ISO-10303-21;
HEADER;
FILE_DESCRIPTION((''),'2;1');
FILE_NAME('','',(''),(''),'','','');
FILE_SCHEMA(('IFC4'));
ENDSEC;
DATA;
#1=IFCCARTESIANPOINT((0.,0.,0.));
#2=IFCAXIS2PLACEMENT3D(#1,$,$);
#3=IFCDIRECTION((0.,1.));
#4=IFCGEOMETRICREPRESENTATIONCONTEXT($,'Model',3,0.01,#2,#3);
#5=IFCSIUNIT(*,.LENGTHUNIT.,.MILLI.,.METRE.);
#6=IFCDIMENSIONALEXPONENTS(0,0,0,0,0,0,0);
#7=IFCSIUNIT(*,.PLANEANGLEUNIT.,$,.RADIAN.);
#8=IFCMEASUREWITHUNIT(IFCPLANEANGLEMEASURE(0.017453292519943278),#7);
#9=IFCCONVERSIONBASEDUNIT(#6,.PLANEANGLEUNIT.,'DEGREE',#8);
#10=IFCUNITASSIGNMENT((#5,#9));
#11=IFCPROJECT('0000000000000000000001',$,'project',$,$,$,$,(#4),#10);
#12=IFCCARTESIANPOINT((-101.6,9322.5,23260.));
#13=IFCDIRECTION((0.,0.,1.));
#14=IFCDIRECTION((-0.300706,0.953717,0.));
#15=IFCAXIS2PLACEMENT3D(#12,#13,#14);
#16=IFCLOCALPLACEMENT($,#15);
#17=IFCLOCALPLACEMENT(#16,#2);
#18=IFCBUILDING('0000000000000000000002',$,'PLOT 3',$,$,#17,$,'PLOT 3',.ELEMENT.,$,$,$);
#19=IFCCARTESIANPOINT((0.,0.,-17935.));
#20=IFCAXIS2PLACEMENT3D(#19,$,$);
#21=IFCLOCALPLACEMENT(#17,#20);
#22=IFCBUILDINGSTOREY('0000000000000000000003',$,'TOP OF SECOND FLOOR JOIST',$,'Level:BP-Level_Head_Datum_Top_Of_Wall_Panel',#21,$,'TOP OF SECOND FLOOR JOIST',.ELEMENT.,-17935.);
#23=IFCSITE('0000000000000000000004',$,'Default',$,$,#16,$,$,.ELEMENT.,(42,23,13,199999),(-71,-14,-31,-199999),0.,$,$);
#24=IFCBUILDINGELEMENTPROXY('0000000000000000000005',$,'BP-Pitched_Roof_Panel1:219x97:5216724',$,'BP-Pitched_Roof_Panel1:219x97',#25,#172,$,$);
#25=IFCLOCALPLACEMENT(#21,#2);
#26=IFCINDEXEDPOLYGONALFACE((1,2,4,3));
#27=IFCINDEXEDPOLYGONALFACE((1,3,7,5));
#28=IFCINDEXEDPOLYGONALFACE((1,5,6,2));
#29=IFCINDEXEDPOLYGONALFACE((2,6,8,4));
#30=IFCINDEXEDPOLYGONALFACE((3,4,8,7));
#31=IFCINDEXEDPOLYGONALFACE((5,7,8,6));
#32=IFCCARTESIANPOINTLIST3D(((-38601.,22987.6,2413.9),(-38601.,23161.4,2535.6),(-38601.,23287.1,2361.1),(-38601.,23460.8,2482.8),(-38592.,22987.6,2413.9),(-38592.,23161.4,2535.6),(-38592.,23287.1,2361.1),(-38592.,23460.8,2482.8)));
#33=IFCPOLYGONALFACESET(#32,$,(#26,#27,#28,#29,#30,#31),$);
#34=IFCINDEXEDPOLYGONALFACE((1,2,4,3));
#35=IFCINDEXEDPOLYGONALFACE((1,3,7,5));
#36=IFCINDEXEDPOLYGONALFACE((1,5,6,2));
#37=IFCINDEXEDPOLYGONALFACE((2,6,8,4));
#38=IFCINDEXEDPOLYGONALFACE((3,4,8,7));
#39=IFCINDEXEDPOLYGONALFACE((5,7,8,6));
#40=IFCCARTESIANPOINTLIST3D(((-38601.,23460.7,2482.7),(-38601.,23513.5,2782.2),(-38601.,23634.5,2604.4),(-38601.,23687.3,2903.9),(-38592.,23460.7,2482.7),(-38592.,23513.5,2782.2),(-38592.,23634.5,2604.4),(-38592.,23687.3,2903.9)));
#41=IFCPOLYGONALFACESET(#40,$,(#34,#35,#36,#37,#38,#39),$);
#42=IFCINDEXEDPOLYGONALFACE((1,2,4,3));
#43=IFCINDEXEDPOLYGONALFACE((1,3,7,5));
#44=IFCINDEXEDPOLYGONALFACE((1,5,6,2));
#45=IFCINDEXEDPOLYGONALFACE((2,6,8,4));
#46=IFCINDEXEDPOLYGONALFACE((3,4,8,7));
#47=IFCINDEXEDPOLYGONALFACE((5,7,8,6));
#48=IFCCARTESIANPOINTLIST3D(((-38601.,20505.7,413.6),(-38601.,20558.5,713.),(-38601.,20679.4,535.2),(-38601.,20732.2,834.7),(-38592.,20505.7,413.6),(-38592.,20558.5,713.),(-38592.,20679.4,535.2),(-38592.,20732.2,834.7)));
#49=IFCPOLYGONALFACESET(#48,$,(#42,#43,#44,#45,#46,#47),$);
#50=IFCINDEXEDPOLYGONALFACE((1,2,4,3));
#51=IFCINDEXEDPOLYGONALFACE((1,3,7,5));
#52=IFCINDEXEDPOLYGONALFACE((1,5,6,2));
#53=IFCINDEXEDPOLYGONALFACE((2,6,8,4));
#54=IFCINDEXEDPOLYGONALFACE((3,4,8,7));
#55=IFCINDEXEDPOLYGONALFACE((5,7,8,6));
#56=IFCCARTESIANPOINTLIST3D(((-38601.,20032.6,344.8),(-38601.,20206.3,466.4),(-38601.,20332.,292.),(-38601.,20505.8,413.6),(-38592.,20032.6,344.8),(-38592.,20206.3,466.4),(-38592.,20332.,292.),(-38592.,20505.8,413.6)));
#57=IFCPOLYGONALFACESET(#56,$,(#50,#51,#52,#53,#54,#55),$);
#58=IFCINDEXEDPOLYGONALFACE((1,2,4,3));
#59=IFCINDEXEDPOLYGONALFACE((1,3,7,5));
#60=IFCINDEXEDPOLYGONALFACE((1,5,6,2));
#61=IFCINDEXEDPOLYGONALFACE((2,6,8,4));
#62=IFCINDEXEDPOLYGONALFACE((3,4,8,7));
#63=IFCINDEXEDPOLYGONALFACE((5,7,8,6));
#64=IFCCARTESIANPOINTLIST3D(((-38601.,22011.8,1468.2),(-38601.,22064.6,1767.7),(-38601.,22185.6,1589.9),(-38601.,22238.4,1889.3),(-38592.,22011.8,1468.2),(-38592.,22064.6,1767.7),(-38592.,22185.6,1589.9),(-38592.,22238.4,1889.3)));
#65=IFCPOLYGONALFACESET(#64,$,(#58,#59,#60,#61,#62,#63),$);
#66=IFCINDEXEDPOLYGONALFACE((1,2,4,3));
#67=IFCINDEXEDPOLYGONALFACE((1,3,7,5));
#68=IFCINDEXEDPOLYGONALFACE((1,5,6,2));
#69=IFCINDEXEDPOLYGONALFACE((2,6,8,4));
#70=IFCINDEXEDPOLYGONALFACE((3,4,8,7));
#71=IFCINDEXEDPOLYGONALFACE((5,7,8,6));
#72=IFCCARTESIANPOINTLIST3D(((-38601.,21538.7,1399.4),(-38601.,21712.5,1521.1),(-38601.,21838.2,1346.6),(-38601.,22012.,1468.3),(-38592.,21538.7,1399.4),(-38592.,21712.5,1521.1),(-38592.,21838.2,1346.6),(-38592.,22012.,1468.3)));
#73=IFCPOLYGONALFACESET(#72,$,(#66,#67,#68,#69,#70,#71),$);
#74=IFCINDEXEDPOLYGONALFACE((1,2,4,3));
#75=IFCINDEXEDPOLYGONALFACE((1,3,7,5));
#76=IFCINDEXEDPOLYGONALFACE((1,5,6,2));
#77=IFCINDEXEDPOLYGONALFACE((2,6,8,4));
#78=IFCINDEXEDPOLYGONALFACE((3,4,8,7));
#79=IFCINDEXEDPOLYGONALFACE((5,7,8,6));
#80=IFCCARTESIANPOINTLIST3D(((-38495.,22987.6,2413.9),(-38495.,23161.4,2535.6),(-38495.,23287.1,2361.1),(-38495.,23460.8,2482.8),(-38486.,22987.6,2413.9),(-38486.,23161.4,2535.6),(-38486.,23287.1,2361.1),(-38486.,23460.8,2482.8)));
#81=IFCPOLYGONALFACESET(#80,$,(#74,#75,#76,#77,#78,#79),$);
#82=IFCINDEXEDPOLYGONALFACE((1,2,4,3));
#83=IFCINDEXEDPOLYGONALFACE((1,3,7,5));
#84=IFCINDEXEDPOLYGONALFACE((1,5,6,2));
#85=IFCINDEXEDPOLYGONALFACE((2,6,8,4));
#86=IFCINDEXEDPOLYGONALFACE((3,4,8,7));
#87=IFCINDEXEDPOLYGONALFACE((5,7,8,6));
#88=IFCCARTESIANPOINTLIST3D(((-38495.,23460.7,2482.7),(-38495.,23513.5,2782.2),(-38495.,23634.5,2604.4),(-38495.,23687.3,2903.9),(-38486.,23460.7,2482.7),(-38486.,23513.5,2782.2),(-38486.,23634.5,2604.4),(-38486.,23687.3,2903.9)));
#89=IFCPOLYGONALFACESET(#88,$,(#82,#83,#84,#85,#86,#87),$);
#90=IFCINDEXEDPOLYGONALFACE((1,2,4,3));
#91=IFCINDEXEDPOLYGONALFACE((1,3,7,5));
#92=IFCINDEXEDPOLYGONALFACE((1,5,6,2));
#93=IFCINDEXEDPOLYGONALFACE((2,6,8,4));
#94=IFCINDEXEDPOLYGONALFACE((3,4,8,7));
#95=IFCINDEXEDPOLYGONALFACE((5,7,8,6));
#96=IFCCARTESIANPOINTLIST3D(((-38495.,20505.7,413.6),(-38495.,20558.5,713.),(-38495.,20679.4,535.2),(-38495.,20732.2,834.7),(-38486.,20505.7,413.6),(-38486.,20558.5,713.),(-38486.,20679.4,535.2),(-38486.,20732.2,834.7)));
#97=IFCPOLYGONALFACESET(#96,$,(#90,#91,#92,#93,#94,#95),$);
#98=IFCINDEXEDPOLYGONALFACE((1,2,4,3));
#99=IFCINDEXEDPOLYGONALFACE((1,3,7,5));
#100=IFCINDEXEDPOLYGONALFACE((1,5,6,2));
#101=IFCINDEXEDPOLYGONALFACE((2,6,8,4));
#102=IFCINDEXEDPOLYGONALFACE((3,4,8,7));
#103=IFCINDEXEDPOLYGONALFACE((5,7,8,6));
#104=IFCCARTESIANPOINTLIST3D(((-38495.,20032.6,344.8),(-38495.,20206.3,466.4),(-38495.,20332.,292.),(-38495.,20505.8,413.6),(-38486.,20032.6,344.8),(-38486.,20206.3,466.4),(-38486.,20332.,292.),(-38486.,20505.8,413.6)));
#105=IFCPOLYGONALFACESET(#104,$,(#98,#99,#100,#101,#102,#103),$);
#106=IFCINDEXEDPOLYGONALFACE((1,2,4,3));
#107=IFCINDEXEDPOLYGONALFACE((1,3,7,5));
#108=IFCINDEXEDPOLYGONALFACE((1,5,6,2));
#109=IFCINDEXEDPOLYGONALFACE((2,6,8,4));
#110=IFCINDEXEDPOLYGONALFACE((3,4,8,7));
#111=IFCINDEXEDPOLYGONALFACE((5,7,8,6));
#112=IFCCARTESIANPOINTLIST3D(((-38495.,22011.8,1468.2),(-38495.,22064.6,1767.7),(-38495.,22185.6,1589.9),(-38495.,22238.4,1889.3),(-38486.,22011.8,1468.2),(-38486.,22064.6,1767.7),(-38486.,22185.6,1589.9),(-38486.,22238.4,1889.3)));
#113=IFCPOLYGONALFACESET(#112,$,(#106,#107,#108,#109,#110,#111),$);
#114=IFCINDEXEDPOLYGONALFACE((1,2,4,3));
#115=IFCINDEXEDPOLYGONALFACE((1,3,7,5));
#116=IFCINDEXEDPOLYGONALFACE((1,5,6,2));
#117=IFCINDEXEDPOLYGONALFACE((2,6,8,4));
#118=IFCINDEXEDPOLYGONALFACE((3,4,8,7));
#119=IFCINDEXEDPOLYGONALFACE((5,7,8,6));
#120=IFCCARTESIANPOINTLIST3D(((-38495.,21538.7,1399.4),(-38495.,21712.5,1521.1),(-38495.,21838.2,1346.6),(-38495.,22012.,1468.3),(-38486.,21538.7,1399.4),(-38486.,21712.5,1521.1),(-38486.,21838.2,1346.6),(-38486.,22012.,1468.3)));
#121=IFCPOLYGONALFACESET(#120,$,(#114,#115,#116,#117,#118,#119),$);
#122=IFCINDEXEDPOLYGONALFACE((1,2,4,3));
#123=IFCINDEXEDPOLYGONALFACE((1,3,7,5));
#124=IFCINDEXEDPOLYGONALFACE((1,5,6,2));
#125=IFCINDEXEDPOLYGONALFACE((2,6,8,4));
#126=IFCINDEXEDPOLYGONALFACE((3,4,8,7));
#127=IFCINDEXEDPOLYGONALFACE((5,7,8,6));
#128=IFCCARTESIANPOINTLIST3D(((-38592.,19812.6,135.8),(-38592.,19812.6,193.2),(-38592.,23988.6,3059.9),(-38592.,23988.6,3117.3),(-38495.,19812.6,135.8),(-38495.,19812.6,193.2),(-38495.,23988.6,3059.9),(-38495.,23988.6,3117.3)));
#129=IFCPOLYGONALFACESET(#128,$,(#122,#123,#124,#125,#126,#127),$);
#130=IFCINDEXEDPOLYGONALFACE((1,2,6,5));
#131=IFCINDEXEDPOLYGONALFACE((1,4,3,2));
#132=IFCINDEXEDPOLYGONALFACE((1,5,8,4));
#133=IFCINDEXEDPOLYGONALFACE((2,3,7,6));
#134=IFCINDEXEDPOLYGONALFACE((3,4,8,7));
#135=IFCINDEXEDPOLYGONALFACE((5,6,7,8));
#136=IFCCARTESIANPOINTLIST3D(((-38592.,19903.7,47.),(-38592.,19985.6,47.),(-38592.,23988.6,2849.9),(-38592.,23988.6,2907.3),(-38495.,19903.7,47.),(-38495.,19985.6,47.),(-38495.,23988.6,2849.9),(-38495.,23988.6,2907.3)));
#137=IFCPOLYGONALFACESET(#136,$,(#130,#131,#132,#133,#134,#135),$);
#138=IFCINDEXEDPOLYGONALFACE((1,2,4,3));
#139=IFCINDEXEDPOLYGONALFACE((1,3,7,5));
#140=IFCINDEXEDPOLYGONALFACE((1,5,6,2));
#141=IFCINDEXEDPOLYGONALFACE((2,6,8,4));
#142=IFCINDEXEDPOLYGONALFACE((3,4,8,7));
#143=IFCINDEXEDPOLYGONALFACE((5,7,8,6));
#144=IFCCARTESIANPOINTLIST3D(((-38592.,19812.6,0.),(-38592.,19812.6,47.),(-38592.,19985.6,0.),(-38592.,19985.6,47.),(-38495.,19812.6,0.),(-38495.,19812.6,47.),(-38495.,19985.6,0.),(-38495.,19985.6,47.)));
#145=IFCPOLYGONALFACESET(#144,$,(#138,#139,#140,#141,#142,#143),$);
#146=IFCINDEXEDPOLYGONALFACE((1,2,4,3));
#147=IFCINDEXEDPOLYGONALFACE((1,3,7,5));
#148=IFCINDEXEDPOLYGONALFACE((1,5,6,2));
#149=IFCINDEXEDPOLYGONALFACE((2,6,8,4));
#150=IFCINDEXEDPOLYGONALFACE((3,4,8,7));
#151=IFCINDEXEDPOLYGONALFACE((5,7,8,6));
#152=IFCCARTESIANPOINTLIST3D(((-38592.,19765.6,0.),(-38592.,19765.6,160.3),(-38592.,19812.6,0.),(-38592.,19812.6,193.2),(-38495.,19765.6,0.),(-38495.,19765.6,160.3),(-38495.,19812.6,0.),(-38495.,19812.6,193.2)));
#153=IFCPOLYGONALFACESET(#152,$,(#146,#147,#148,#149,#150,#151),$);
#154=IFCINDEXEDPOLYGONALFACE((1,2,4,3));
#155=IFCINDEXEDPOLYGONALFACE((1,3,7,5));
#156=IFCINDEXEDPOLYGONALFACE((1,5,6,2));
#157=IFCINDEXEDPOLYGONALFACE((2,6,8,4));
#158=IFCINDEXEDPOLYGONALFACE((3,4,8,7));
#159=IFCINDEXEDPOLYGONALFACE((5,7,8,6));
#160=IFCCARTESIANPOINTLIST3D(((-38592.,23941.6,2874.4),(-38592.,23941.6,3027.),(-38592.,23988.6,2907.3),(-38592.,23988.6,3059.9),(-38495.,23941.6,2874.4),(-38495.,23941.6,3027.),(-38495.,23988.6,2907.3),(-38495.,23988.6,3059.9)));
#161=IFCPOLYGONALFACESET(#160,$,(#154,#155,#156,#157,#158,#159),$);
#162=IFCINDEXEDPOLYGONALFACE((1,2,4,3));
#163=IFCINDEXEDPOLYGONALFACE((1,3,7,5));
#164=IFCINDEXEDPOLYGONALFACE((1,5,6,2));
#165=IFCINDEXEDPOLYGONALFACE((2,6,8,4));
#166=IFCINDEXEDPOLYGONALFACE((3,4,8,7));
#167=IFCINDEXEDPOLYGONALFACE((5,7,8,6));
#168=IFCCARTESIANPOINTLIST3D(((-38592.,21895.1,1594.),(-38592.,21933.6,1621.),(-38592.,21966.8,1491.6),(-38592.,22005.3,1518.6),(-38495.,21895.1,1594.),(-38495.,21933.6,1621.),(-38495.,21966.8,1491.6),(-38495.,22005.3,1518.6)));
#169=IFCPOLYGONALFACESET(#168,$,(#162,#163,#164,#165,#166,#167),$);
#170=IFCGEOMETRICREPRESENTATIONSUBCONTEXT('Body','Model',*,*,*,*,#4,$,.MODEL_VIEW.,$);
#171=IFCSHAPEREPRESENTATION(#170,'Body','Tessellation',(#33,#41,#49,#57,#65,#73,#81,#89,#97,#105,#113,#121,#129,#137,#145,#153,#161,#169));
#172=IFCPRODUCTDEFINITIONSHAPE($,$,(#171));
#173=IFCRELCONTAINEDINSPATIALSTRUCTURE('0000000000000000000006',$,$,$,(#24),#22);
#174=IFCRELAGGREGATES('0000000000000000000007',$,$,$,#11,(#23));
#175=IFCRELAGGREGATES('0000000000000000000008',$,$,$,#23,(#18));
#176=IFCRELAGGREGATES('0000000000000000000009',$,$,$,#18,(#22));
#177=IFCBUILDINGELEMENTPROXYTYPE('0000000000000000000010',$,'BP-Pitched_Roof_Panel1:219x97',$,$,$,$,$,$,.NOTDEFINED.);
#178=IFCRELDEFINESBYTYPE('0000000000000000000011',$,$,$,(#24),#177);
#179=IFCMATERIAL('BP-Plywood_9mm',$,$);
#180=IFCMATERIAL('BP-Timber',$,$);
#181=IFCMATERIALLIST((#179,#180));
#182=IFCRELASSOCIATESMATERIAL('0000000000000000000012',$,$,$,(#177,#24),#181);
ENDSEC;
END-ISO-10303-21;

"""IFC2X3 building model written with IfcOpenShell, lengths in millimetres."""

from ifc_helpers import new_model, entity, si_unit, converted_unit, direction, frame, frame_2d, origin, origin_2d_with_axis, place, context, subcontext, project, spatial, polyline, rectangle, outline, extrude, source, transform, mapped, material, material_list, type_object, type_shapes, element, save


model = new_model("IFC2X3")

# Units and contexts
model_context = context("Model", 3, precision=0.01, world=origin(), true_north=direction((0.0, 1.0)))
body_context = subcontext(model_context, "Body", "Model", "MODEL_VIEW")
ifc_project = project(units=[si_unit("LENGTHUNIT", "METRE", prefix="MILLI"), converted_unit("PLANEANGLEUNIT", "DEGREE", entity("IfcPlaneAngleMeasure", 0.017453292519943278), si_unit("PLANEANGLEUNIT", "RADIAN"), dimensions=[0, 0, 0, 0, 0, 0, 0])], contexts=[model_context])

# Site, building, storey
site_placement = place(None, frame((-101.6, 9322.5, 23260.0), z_axis=(0.0, 0.0, 1.0), x_axis=(-0.300706, 0.953717, 0.0)))
site = spatial("IfcSite", under=ifc_project, at=site_placement, Name="Default", CompositionType="ELEMENT", RefLatitude=(42, 23, 13, 199999), RefLongitude=(-71, -14, -31, -199999), RefElevation=0.0)
building_placement = place(site_placement, origin())
building = spatial("IfcBuilding", under=site, at=building_placement, Name="PLOT 3", LongName="PLOT 3", CompositionType="ELEMENT")
storey_placement = place(building_placement, frame((0.0, 0.0, -17935.0)))
storey = spatial("IfcBuildingStorey", under=building, at=storey_placement, Name="TOP OF SECOND FLOOR JOIST", ObjectType="Level:BP-Level_Head_Datum_Top_Of_Wall_Panel", LongName="TOP OF SECOND FLOOR JOIST", CompositionType="ELEMENT", Elevation=-17935.0)

# Building element proxy
ifc_material_1 = material(Name="BP-Timber")
ifc_material_2 = material(Name="BP-Plywood_9mm")
ifc_material_list = material_list([ifc_material_2, ifc_material_1])
building_element_proxy_type_1 = type_object("IfcBuildingElementProxyType", Name="BP-Pitched_Roof_Panel1:219x97", PredefinedType="NOTDEFINED", material=ifc_material_list)
shared_shape_1 = source(origin(), body_context, "Body", "SweptSolid", [
    extrude(outline(polyline([(-77.0, -75.0), (227.0, -75.0), (77.0, 75.0), (-227.0, 75.0), (-77.0, -75.0)])), frame((36.3, 3947.0, 2448.4), z_axis=(0.0, 1.0, 0.0), x_axis=(-0.984808, 0.0, 0.173648)), (0.0, 0.0, 1.0), 9.0),
    extrude(outline(polyline([(1.4, -107.5), (213.6, -107.5), (-1.4, 107.5), (-213.6, 107.5), (1.4, -107.5)])), frame((386.1, 3947.0, 2693.3), z_axis=(0.0, 1.0, 0.0), x_axis=(-0.819152, 0.0, -0.573576)), (0.0, 0.0, 1.0), 9.0),
    extrude(outline(polyline([(1.4, -107.5), (213.6, -107.5), (-1.4, 107.5), (-213.6, 107.5), (1.4, -107.5)])), frame((-2569.0, 3947.0, 624.1), z_axis=(0.0, 1.0, 0.0), x_axis=(-0.819152, 0.0, -0.573576)), (0.0, 0.0, 1.0), 9.0),
    extrude(outline(polyline([(-77.0, -75.0), (227.0, -75.0), (77.0, 75.0), (-227.0, 75.0), (-77.0, -75.0)])), frame((-2918.8, 3947.0, 379.2), z_axis=(0.0, 1.0, 0.0), x_axis=(-0.984808, 0.0, 0.173648)), (0.0, 0.0, 1.0), 9.0),
    extrude(outline(polyline([(1.4, -107.5), (213.6, -107.5), (-1.4, 107.5), (-213.6, 107.5), (1.4, -107.5)])), frame((-1062.8, 3947.0, 1678.8), z_axis=(0.0, 1.0, 0.0), x_axis=(-0.819152, 0.0, -0.573576)), (0.0, 0.0, 1.0), 9.0),
    extrude(outline(polyline([(-77.0, -75.0), (227.0, -75.0), (77.0, 75.0), (-227.0, 75.0), (-77.0, -75.0)])), frame((-1412.6, 3947.0, 1433.9), z_axis=(0.0, 1.0, 0.0), x_axis=(-0.984808, 0.0, 0.173648)), (0.0, 0.0, 1.0), 9.0),
    extrude(outline(polyline([(-77.0, -75.0), (227.0, -75.0), (77.0, 75.0), (-227.0, 75.0), (-77.0, -75.0)])), frame((36.3, 3841.0, 2448.4), z_axis=(0.0, 1.0, 0.0), x_axis=(-0.984808, 0.0, 0.173648)), (0.0, 0.0, 1.0), 9.0),
    extrude(outline(polyline([(1.4, -107.5), (213.6, -107.5), (-1.4, 107.5), (-213.6, 107.5), (1.4, -107.5)])), frame((386.1, 3841.0, 2693.3), z_axis=(0.0, 1.0, 0.0), x_axis=(-0.819152, 0.0, -0.573576)), (0.0, 0.0, 1.0), 9.0),
    extrude(outline(polyline([(1.4, -107.5), (213.6, -107.5), (-1.4, 107.5), (-213.6, 107.5), (1.4, -107.5)])), frame((-2569.0, 3841.0, 624.1), z_axis=(0.0, 1.0, 0.0), x_axis=(-0.819152, 0.0, -0.573576)), (0.0, 0.0, 1.0), 9.0),
    extrude(outline(polyline([(-77.0, -75.0), (227.0, -75.0), (77.0, 75.0), (-227.0, 75.0), (-77.0, -75.0)])), frame((-2918.8, 3841.0, 379.2), z_axis=(0.0, 1.0, 0.0), x_axis=(-0.984808, 0.0, 0.173648)), (0.0, 0.0, 1.0), 9.0),
    extrude(outline(polyline([(1.4, -107.5), (213.6, -107.5), (-1.4, 107.5), (-213.6, 107.5), (1.4, -107.5)])), frame((-1062.8, 3841.0, 1678.8), z_axis=(0.0, 1.0, 0.0), x_axis=(-0.819152, 0.0, -0.573576)), (0.0, 0.0, 1.0), 9.0),
    extrude(outline(polyline([(-77.0, -75.0), (227.0, -75.0), (77.0, 75.0), (-227.0, 75.0), (-77.0, -75.0)])), frame((-1412.6, 3841.0, 1433.9), z_axis=(0.0, 1.0, 0.0), x_axis=(-0.984808, 0.0, 0.173648)), (0.0, 0.0, 1.0), 9.0),
    extrude(outline(polyline([(-1490.7, -2088.0), (-1433.3, -2088.0), (1490.7, 2088.0), (1433.3, 2088.0), (-1490.7, -2088.0)])), frame((-1287.3, 3850.0, 1626.6), z_axis=(0.0, 1.0, 0.0), x_axis=(0.0, 0.0, -1.0)), (0.0, 0.0, 1.0), 97.0),
    extrude(outline(polyline([(-1444.5, -2022.0), (-1387.1, -2022.0), (1415.8, 1981.0), (1415.8, 2063.0), (-1444.5, -2022.0)])), frame((-1221.3, 3850.0, 1462.8), z_axis=(0.0, 1.0, 0.0), x_axis=(0.0, 0.0, -1.0)), (0.0, 0.0, 1.0), 97.0),
    extrude(rectangle(XDim=97.0, YDim=173.0, at=origin_2d_with_axis()), frame((-3288.8, 3898.5, 0.0), z_axis=(0.0, 0.0, 1.0), x_axis=(0.0, 1.0, 0.0)), (0.0, 0.0, 1.0), 47.0),
    extrude(outline(polyline([(22.0, -72.4), (79.4, -72.4), (-31.4, 85.9), (-69.9, 58.9), (22.0, -72.4)])), frame((-3398.8, 3850.0, 88.4), z_axis=(0.0, 1.0, 0.0), x_axis=(0.819152, 0.0, 0.573576)), (0.0, 0.0, 1.0), 97.0),
    extrude(outline(polyline([(15.1, -62.5), (72.5, -62.5), (-15.1, 62.5), (-72.5, 62.5), (15.1, -62.5)])), frame((777.2, 3850.0, 2967.2), z_axis=(0.0, 1.0, 0.0), x_axis=(0.819152, 0.0, 0.573576)), (0.0, 0.0, 1.0), 97.0),
    extrude(rectangle(XDim=47.0, YDim=97.0, at=frame_2d((0.0, 0.0), x_axis=(0.0, 1.0))), frame((-1201.9, 3898.5, 1505.1), z_axis=(-0.573576, 0.0, 0.819152), x_axis=(0.0, 1.0, 0.0)), (0.0, 0.0, 1.0), 125.0),
])
type_shapes(building_element_proxy_type_1, [shared_shape_1])
for number, where, z_axis, x_axis, name in (
    (1, (-34645.0, 23187.9, 0.0), (0.0, 0.0, 1.0), (0.0, 1.0, 0.0), "BP-Pitched_Roof_Panel1:219x97:5216724"),
):
    element("IfcBuildingElementProxy", number, at=place(storey_placement, frame(where, z_axis=z_axis, x_axis=x_axis)), inside=storey, type_object=building_element_proxy_type_1, material=ifc_material_list, Name=name, ObjectType="BP-Pitched_Roof_Panel1:219x97", context=body_context, shape_type="MappedRepresentation", body=[
        mapped(shared_shape_1, transform((0.0, 0.0, 0.0), scale=1.0)),
    ])

save(model, "model.ifc")
